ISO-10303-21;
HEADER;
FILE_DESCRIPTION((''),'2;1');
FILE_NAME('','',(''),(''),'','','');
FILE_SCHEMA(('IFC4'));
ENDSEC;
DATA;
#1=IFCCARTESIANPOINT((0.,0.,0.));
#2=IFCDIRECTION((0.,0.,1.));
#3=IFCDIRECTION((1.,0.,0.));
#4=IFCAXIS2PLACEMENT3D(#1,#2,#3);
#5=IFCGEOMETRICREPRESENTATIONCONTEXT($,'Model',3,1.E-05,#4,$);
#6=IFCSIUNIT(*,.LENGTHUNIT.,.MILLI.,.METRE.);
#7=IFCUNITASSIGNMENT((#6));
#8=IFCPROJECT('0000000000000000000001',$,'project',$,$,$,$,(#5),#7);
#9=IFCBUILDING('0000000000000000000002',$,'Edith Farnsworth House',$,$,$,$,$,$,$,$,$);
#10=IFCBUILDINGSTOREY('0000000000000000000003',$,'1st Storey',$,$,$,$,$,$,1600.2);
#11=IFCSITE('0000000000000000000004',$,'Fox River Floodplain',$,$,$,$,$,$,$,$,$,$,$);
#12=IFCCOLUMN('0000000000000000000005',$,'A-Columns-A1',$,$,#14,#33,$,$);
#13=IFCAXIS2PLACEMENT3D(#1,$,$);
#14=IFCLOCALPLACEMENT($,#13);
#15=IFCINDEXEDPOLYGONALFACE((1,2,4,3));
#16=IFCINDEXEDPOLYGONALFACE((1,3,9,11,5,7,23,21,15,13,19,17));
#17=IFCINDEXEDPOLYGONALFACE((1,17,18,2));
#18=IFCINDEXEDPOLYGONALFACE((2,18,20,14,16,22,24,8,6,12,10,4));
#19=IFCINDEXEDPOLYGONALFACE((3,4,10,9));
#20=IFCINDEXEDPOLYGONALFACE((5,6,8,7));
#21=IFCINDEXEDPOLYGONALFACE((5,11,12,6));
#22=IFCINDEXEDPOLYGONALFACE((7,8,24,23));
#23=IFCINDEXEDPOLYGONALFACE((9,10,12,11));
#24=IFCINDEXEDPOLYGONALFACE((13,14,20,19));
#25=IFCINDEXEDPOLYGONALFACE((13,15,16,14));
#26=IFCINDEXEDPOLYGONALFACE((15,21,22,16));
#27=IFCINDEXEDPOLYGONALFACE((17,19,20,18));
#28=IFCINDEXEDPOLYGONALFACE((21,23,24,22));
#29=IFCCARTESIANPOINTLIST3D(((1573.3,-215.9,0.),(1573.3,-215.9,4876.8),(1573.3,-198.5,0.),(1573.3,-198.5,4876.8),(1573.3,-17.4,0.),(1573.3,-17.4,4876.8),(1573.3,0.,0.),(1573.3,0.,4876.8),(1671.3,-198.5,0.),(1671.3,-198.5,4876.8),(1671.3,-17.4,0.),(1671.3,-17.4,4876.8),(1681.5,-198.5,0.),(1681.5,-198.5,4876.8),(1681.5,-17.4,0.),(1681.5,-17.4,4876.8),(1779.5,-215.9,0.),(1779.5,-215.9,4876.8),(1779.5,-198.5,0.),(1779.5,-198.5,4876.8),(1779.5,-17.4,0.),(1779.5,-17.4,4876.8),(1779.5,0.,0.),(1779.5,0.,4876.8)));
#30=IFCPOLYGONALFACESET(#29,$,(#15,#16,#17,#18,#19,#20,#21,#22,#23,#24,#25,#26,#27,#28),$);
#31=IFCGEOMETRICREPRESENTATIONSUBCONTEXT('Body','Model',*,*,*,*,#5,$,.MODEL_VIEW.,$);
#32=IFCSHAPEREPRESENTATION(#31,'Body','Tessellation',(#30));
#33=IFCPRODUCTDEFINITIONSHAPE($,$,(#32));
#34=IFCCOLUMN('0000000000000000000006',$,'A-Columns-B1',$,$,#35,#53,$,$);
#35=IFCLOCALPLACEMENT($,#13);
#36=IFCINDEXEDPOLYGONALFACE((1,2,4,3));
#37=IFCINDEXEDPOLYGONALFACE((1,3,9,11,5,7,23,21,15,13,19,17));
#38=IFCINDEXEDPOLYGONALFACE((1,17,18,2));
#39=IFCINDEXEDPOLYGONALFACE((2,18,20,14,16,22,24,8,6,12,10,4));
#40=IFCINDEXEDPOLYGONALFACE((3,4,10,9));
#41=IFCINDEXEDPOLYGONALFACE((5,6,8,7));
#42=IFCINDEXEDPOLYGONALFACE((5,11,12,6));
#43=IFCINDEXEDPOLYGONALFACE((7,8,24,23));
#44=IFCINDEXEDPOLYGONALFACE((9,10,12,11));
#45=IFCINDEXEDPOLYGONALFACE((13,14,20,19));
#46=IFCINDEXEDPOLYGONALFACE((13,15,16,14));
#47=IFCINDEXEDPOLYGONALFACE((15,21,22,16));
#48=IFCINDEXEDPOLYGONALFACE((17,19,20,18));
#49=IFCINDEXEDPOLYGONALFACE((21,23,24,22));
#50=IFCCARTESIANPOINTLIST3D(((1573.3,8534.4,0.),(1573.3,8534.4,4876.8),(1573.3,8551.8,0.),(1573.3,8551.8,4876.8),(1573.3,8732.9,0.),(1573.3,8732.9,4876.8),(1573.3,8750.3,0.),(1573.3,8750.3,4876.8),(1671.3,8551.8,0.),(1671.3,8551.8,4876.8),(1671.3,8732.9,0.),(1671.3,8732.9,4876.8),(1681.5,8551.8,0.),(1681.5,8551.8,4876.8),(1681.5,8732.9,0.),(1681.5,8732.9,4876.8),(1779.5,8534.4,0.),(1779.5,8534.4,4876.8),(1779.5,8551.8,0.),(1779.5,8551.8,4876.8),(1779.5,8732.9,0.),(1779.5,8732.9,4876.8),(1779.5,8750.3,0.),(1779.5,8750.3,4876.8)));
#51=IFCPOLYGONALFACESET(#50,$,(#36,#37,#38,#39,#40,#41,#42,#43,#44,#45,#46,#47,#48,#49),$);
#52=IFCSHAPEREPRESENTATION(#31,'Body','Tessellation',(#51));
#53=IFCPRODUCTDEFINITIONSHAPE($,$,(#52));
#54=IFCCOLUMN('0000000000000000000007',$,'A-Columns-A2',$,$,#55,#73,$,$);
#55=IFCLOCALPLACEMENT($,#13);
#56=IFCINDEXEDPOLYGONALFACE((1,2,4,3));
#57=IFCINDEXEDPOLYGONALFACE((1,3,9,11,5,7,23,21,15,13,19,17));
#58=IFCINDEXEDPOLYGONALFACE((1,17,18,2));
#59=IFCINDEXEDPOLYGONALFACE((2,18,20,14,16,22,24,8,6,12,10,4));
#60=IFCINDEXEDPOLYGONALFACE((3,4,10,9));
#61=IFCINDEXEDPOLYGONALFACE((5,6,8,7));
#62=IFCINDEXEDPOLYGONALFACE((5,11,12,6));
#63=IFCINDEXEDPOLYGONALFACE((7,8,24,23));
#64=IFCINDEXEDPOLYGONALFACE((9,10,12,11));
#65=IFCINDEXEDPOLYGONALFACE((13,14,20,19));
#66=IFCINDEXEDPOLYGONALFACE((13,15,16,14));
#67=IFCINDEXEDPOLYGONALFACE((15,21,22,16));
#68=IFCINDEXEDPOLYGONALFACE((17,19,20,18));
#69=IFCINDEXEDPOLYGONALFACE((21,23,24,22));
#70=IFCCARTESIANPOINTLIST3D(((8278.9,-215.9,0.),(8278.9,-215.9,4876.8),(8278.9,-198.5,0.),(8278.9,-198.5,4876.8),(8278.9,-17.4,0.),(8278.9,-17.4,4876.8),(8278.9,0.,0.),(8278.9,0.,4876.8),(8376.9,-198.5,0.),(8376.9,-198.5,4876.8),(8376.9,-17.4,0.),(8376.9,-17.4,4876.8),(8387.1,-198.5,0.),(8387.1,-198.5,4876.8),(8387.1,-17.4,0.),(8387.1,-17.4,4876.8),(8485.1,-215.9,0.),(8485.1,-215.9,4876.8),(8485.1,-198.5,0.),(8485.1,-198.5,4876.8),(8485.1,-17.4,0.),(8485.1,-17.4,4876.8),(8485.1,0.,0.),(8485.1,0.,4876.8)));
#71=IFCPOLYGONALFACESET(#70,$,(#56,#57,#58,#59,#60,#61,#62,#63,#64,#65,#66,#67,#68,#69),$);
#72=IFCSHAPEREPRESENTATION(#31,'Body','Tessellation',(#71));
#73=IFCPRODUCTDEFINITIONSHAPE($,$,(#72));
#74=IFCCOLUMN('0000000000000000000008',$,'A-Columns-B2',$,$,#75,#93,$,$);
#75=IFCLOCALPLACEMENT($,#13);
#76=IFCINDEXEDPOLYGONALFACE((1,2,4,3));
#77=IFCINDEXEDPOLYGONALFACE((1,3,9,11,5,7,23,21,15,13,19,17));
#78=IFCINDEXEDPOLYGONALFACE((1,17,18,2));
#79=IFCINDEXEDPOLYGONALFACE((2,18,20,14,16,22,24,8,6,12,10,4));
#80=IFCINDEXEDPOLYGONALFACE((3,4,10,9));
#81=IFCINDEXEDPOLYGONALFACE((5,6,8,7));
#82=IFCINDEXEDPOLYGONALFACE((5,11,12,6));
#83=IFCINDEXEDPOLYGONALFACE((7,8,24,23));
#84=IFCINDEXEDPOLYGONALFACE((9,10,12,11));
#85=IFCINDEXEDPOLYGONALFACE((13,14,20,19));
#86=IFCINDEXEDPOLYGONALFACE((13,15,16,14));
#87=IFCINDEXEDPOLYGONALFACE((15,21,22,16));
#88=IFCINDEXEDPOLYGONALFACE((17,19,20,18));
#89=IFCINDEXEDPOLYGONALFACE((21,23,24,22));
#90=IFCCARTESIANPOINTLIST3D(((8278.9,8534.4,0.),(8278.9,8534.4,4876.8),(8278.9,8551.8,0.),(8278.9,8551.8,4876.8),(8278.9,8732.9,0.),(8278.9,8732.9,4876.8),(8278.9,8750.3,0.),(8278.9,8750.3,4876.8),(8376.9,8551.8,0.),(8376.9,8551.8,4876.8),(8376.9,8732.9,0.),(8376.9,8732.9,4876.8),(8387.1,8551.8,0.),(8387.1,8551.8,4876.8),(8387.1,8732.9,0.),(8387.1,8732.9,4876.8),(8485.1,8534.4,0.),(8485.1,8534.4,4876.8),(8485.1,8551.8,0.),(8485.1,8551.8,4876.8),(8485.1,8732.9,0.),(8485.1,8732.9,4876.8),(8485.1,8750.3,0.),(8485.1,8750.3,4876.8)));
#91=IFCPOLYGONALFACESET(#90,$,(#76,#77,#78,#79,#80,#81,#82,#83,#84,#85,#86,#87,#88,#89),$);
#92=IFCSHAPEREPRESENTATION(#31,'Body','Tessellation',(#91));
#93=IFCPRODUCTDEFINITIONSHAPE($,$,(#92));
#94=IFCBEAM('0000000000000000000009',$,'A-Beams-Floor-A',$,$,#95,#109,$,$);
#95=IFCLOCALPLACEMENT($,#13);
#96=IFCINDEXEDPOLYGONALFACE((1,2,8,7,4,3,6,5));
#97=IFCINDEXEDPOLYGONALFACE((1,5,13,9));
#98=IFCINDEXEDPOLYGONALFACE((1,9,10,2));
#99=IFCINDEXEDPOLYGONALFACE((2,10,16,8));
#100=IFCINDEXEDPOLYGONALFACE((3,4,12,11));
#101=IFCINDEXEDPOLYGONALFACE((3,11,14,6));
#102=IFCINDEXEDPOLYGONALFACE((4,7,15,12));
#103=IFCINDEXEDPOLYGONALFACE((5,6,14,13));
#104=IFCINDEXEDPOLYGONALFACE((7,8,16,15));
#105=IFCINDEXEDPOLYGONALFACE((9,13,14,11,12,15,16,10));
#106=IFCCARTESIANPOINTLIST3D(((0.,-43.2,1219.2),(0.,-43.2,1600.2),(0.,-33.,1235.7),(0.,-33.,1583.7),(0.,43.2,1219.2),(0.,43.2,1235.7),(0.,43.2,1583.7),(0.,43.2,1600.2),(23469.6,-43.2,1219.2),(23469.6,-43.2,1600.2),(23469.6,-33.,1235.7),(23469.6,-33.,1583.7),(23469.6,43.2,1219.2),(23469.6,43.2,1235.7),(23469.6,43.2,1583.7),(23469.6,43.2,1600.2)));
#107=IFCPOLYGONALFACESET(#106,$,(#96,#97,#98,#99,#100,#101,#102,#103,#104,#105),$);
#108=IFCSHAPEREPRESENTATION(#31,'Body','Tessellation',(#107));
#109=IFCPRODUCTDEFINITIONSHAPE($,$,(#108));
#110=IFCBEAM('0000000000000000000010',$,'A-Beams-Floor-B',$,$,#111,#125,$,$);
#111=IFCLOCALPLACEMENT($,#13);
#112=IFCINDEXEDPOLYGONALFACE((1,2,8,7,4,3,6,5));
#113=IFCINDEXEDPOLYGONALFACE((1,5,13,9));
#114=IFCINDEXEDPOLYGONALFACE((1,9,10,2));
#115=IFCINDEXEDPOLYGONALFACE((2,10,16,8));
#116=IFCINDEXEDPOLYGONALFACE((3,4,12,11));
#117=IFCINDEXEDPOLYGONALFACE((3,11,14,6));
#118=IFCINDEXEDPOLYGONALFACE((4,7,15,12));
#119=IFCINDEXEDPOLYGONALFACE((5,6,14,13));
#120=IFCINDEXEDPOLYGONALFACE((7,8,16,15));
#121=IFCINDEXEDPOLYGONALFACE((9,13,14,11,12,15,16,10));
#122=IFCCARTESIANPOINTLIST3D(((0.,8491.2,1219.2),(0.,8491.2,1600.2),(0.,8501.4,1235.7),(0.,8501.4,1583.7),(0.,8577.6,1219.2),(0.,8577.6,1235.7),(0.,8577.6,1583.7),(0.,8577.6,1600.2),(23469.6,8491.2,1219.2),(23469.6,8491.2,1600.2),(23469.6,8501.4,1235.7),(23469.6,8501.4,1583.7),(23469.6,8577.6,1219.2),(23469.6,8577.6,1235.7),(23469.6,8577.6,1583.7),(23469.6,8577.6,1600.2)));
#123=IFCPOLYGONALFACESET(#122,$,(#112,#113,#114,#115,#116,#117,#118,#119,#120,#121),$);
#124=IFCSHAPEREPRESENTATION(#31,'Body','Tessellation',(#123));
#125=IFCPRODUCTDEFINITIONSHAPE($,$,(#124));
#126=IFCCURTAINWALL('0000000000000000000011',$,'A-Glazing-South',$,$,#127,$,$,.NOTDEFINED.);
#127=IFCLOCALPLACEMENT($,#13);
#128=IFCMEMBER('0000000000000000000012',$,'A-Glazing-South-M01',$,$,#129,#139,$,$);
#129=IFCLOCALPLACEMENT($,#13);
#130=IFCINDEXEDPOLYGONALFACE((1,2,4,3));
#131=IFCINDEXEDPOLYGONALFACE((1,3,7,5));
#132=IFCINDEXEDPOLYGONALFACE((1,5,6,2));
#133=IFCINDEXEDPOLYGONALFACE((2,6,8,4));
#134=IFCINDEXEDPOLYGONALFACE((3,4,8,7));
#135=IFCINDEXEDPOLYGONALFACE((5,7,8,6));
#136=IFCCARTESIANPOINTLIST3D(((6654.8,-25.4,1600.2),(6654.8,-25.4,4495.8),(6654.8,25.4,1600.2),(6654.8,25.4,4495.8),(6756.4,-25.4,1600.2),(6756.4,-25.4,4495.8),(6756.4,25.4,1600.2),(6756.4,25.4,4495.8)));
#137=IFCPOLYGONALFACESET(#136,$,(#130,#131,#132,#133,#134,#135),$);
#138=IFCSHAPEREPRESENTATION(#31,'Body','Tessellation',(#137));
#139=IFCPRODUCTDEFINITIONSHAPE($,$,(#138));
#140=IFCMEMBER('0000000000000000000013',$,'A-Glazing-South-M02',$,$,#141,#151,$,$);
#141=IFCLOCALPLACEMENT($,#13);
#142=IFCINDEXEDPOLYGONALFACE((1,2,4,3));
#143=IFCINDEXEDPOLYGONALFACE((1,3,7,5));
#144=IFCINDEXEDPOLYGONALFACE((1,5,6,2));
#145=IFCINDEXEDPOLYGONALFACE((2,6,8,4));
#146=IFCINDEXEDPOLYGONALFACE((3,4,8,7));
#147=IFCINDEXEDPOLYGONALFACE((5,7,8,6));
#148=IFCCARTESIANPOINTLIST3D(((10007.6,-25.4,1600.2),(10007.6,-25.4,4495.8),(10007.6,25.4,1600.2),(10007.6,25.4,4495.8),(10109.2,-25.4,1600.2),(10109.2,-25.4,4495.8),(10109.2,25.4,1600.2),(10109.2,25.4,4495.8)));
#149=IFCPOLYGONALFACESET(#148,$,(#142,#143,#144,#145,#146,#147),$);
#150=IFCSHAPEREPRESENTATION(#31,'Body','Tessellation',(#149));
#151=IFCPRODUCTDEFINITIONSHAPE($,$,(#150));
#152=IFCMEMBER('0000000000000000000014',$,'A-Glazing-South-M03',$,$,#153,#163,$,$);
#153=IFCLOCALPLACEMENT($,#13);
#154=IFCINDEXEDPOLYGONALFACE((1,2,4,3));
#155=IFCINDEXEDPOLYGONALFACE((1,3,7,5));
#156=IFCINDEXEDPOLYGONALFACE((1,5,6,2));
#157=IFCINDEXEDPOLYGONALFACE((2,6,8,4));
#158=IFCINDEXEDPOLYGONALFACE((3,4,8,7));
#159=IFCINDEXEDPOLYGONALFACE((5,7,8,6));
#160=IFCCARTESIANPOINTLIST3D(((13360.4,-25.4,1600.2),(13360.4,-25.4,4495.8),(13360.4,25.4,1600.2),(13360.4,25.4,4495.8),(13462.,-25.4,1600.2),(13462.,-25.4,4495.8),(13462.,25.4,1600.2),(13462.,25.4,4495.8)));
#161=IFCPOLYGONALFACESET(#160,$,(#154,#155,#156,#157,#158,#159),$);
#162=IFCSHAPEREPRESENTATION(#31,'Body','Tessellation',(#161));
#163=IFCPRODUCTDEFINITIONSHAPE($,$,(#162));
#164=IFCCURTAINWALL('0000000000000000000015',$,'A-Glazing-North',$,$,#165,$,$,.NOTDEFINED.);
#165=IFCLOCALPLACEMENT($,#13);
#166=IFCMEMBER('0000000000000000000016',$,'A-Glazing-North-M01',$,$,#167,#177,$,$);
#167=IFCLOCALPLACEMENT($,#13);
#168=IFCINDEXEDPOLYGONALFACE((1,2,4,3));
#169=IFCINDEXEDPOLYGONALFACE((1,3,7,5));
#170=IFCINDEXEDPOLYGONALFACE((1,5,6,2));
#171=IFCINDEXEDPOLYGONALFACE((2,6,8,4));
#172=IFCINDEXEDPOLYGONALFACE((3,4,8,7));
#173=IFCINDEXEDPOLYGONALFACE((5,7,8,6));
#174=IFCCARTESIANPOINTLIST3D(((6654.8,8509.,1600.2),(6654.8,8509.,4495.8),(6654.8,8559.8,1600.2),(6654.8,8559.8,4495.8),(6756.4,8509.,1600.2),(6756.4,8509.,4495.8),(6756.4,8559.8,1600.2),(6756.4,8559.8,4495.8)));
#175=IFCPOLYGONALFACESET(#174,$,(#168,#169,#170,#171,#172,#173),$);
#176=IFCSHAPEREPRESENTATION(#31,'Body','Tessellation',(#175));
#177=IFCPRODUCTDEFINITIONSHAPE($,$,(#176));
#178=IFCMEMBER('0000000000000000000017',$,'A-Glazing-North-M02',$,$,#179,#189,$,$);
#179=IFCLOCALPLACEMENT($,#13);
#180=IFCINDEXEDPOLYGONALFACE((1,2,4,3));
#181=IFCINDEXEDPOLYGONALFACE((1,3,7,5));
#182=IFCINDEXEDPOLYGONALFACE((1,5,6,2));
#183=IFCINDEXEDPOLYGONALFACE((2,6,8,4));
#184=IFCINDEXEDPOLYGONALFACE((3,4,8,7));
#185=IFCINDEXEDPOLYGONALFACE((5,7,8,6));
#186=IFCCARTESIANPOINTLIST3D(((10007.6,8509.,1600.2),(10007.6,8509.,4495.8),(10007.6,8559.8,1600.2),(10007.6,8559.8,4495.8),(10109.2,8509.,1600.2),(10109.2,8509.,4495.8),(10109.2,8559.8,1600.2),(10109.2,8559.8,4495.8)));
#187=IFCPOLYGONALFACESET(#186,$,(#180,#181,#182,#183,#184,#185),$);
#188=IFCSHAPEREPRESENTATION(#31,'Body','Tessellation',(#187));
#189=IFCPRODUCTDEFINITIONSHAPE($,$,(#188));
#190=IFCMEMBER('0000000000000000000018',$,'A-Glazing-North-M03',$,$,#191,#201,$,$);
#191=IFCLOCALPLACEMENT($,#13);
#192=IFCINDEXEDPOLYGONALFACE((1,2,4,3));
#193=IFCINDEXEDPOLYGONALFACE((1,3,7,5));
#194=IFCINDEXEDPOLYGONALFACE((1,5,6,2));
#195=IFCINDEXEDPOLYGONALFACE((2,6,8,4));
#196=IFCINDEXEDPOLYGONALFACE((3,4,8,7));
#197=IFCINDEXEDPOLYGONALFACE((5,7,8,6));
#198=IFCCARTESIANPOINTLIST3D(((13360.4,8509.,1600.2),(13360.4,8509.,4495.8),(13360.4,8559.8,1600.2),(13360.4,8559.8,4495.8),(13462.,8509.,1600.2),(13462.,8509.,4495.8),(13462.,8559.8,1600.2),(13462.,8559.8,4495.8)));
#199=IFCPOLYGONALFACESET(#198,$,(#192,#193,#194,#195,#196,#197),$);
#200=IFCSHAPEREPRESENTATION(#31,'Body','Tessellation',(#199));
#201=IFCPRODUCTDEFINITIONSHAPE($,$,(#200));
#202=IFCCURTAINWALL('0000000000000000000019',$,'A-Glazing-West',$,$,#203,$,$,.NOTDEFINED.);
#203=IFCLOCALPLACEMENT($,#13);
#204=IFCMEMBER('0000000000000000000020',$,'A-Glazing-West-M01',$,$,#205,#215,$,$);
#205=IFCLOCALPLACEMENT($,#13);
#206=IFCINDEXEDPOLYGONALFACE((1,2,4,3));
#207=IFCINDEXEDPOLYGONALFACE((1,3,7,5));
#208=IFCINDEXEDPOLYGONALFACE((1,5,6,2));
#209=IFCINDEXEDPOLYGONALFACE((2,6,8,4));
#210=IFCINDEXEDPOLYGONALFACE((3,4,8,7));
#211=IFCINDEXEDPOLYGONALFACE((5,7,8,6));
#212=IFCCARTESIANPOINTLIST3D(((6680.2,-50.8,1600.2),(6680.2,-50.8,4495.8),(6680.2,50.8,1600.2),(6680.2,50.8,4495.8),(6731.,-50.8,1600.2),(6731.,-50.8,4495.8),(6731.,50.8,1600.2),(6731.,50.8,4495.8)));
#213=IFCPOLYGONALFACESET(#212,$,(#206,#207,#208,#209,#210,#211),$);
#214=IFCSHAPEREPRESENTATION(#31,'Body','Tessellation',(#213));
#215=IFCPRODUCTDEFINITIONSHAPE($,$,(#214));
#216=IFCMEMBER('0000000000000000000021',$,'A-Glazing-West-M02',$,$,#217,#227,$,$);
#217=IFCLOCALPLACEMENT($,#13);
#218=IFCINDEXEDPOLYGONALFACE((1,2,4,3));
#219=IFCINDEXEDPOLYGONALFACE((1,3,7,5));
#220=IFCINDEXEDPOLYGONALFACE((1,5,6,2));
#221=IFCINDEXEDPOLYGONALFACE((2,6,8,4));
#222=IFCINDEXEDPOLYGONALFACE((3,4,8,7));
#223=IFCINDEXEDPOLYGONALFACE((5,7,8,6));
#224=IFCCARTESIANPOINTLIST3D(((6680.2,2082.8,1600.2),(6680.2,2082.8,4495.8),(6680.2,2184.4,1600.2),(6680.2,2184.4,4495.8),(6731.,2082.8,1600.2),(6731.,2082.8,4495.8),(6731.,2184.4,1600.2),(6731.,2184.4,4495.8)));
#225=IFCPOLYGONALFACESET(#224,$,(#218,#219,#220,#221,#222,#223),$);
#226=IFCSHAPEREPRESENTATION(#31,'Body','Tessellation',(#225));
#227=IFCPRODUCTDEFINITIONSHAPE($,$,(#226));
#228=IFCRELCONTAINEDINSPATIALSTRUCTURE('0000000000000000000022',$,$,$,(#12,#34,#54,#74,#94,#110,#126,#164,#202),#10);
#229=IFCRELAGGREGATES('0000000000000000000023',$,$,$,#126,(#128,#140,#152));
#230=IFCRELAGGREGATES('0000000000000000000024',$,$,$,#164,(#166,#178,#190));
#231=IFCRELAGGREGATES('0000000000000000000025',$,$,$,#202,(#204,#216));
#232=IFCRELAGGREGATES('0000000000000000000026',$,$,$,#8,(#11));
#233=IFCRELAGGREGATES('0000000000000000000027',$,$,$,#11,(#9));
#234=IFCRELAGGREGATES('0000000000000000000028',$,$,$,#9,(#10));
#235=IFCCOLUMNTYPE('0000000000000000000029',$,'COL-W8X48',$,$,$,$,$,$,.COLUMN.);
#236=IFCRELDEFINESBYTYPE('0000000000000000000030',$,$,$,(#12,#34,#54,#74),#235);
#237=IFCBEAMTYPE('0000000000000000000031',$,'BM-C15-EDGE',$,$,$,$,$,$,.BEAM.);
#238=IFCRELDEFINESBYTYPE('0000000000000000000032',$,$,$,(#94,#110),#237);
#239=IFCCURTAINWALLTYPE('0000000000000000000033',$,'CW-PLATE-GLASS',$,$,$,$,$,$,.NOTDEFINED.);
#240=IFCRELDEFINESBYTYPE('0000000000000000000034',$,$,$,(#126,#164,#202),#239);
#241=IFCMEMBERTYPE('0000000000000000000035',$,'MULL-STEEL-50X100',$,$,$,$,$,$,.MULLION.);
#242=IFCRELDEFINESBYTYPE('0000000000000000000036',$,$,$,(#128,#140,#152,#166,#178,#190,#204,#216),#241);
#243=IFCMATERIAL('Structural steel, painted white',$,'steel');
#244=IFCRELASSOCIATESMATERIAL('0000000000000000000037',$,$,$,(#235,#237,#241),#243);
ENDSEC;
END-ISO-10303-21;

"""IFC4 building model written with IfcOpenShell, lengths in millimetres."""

from ifc_helpers import new_model, si_unit, frame, origin, origin_with_axes, place, context, subcontext, project, spatial, rectangle, i_section, u_section, extrude, material, type_object, element, aggregate, save


model = new_model("IFC4")

# Units and contexts
model_context = context("Model", 3, precision=1e-05, world=origin_with_axes())
body_context = subcontext(model_context, "Body", "Model", "MODEL_VIEW")
ifc_project = project(units=[si_unit("LENGTHUNIT", "METRE", prefix="MILLI")], contexts=[model_context])

# Site, building, storey
site = spatial("IfcSite", under=ifc_project, Name="Fox River Floodplain")
building = spatial("IfcBuilding", under=site, Name="Edith Farnsworth House")
storey = spatial("IfcBuildingStorey", under=building, Name="1st Storey", Elevation=1600.2)

# Columns
ifc_material_1 = material(Name="Structural steel, painted white", Category="steel")
column_type = type_object("IfcColumnType", Name="COL-W8X48", PredefinedType="COLUMN", material=ifc_material_1)
for number, where, z_axis, x_axis, name in (
    (1, (1676.4, -108.0, 0.0), (0.0, 0.0, 1.0), (1.0, 0.0, 0.0), "A-Columns-A1"),
    (2, (1676.4, 8642.4, 0.0), (0.0, 0.0, 1.0), (1.0, 0.0, 0.0), "A-Columns-B1"),
    (3, (8382.0, -108.0, 0.0), (0.0, 0.0, 1.0), (1.0, 0.0, 0.0), "A-Columns-A2"),
    (4, (8382.0, 8642.4, 0.0), (0.0, 0.0, 1.0), (1.0, 0.0, 0.0), "A-Columns-B2"),
):
    element("IfcColumn", number, at=place(None, frame(where, z_axis=z_axis, x_axis=x_axis)), inside=storey, type_object=column_type, Name=name, context=body_context, shape_type="SweptSolid", body=[
        extrude(i_section(OverallWidth=206.2, OverallDepth=215.9, WebThickness=10.2, FlangeThickness=17.4), origin(), (0.0, 0.0, 1.0), 4876.8),
    ])

# Beams
beam_type = type_object("IfcBeamType", Name="BM-C15-EDGE", PredefinedType="BEAM", material=ifc_material_1)
for number, where, z_axis, x_axis, name in (
    (5, (0.0, 0.0, 1409.7), (1.0, 0.0, 0.0), (0.0, 1.0, 0.0), "A-Beams-Floor-A"),
    (6, (0.0, 8534.4, 1409.7), (1.0, 0.0, 0.0), (0.0, 1.0, 0.0), "A-Beams-Floor-B"),
):
    element("IfcBeam", number, at=place(None, frame(where, z_axis=z_axis, x_axis=x_axis)), inside=storey, type_object=beam_type, Name=name, context=body_context, shape_type="SweptSolid", body=[
        extrude(u_section(Depth=381.0, FlangeWidth=86.4, WebThickness=10.2, FlangeThickness=16.5), origin(), (0.0, 0.0, 1.0), 23469.6),
    ])

# Curtain walls, members
curtain_wall_type = type_object("IfcCurtainWallType", Name="CW-PLATE-GLASS", PredefinedType="NOTDEFINED")
curtain_wall_1 = element("IfcCurtainWall", 7, inside=storey, type_object=curtain_wall_type, Name="A-Glazing-South", PredefinedType="NOTDEFINED")
member_type = type_object("IfcMemberType", Name="MULL-STEEL-50X100", PredefinedType="MULLION", material=ifc_material_1)
member_1_placement = place(None, frame((6705.6, 0.0, 1600.2), z_axis=(0.0, 0.0, 1.0), x_axis=(0.0, 1.0, 0.0)))
member_1 = element("IfcMember", 8, at=member_1_placement, type_object=member_type, Name="A-Glazing-South-M01", context=body_context, shape_type="SweptSolid", body=[
    extrude(rectangle(XDim=50.8, YDim=101.6), origin(), (0.0, 0.0, 1.0), 2895.6),
])
member_2_placement = place(None, frame((10058.4, 0.0, 1600.2), z_axis=(0.0, 0.0, 1.0), x_axis=(0.0, 1.0, 0.0)))
member_2 = element("IfcMember", 9, at=member_2_placement, type_object=member_type, Name="A-Glazing-South-M02", context=body_context, shape_type="SweptSolid", body=[
    extrude(rectangle(XDim=50.8, YDim=101.6), origin(), (0.0, 0.0, 1.0), 2895.6),
])
member_3_placement = place(None, frame((13411.2, 0.0, 1600.2), z_axis=(0.0, 0.0, 1.0), x_axis=(0.0, 1.0, 0.0)))
member_3 = element("IfcMember", 10, at=member_3_placement, type_object=member_type, Name="A-Glazing-South-M03", context=body_context, shape_type="SweptSolid", body=[
    extrude(rectangle(XDim=50.8, YDim=101.6), origin(), (0.0, 0.0, 1.0), 2895.6),
])
curtain_wall_2 = element("IfcCurtainWall", 11, inside=storey, type_object=curtain_wall_type, Name="A-Glazing-North", PredefinedType="NOTDEFINED")
member_4_placement = place(None, frame((6705.6, 8534.4, 1600.2), z_axis=(0.0, 0.0, 1.0), x_axis=(0.0, 1.0, 0.0)))
member_4 = element("IfcMember", 12, at=member_4_placement, type_object=member_type, Name="A-Glazing-North-M01", context=body_context, shape_type="SweptSolid", body=[
    extrude(rectangle(XDim=50.8, YDim=101.6), origin(), (0.0, 0.0, 1.0), 2895.6),
])
member_5_placement = place(None, frame((10058.4, 8534.4, 1600.2), z_axis=(0.0, 0.0, 1.0), x_axis=(0.0, 1.0, 0.0)))
member_5 = element("IfcMember", 13, at=member_5_placement, type_object=member_type, Name="A-Glazing-North-M02", context=body_context, shape_type="SweptSolid", body=[
    extrude(rectangle(XDim=50.8, YDim=101.6), origin(), (0.0, 0.0, 1.0), 2895.6),
])
member_6_placement = place(None, frame((13411.2, 8534.4, 1600.2), z_axis=(0.0, 0.0, 1.0), x_axis=(0.0, 1.0, 0.0)))
member_6 = element("IfcMember", 14, at=member_6_placement, type_object=member_type, Name="A-Glazing-North-M03", context=body_context, shape_type="SweptSolid", body=[
    extrude(rectangle(XDim=50.8, YDim=101.6), origin(), (0.0, 0.0, 1.0), 2895.6),
])
curtain_wall_3 = element("IfcCurtainWall", 15, inside=storey, type_object=curtain_wall_type, Name="A-Glazing-West", PredefinedType="NOTDEFINED")
member_7_placement = place(None, frame((6705.6, 0.0, 1600.2), z_axis=(0.0, 0.0, 1.0), x_axis=(1.0, 0.0, 0.0)))
member_7 = element("IfcMember", 16, at=member_7_placement, type_object=member_type, Name="A-Glazing-West-M01", context=body_context, shape_type="SweptSolid", body=[
    extrude(rectangle(XDim=50.8, YDim=101.6), origin(), (0.0, 0.0, 1.0), 2895.6),
])
member_8_placement = place(None, frame((6705.6, 2133.6, 1600.2), z_axis=(0.0, 0.0, 1.0), x_axis=(1.0, 0.0, 0.0)))
member_8 = element("IfcMember", 17, at=member_8_placement, type_object=member_type, Name="A-Glazing-West-M02", context=body_context, shape_type="SweptSolid", body=[
    extrude(rectangle(XDim=50.8, YDim=101.6), origin(), (0.0, 0.0, 1.0), 2895.6),
])

aggregate(curtain_wall_1, [member_1, member_2, member_3])
aggregate(curtain_wall_2, [member_4, member_5, member_6])
aggregate(curtain_wall_3, [member_7, member_8])

save(model, "model.ifc")
